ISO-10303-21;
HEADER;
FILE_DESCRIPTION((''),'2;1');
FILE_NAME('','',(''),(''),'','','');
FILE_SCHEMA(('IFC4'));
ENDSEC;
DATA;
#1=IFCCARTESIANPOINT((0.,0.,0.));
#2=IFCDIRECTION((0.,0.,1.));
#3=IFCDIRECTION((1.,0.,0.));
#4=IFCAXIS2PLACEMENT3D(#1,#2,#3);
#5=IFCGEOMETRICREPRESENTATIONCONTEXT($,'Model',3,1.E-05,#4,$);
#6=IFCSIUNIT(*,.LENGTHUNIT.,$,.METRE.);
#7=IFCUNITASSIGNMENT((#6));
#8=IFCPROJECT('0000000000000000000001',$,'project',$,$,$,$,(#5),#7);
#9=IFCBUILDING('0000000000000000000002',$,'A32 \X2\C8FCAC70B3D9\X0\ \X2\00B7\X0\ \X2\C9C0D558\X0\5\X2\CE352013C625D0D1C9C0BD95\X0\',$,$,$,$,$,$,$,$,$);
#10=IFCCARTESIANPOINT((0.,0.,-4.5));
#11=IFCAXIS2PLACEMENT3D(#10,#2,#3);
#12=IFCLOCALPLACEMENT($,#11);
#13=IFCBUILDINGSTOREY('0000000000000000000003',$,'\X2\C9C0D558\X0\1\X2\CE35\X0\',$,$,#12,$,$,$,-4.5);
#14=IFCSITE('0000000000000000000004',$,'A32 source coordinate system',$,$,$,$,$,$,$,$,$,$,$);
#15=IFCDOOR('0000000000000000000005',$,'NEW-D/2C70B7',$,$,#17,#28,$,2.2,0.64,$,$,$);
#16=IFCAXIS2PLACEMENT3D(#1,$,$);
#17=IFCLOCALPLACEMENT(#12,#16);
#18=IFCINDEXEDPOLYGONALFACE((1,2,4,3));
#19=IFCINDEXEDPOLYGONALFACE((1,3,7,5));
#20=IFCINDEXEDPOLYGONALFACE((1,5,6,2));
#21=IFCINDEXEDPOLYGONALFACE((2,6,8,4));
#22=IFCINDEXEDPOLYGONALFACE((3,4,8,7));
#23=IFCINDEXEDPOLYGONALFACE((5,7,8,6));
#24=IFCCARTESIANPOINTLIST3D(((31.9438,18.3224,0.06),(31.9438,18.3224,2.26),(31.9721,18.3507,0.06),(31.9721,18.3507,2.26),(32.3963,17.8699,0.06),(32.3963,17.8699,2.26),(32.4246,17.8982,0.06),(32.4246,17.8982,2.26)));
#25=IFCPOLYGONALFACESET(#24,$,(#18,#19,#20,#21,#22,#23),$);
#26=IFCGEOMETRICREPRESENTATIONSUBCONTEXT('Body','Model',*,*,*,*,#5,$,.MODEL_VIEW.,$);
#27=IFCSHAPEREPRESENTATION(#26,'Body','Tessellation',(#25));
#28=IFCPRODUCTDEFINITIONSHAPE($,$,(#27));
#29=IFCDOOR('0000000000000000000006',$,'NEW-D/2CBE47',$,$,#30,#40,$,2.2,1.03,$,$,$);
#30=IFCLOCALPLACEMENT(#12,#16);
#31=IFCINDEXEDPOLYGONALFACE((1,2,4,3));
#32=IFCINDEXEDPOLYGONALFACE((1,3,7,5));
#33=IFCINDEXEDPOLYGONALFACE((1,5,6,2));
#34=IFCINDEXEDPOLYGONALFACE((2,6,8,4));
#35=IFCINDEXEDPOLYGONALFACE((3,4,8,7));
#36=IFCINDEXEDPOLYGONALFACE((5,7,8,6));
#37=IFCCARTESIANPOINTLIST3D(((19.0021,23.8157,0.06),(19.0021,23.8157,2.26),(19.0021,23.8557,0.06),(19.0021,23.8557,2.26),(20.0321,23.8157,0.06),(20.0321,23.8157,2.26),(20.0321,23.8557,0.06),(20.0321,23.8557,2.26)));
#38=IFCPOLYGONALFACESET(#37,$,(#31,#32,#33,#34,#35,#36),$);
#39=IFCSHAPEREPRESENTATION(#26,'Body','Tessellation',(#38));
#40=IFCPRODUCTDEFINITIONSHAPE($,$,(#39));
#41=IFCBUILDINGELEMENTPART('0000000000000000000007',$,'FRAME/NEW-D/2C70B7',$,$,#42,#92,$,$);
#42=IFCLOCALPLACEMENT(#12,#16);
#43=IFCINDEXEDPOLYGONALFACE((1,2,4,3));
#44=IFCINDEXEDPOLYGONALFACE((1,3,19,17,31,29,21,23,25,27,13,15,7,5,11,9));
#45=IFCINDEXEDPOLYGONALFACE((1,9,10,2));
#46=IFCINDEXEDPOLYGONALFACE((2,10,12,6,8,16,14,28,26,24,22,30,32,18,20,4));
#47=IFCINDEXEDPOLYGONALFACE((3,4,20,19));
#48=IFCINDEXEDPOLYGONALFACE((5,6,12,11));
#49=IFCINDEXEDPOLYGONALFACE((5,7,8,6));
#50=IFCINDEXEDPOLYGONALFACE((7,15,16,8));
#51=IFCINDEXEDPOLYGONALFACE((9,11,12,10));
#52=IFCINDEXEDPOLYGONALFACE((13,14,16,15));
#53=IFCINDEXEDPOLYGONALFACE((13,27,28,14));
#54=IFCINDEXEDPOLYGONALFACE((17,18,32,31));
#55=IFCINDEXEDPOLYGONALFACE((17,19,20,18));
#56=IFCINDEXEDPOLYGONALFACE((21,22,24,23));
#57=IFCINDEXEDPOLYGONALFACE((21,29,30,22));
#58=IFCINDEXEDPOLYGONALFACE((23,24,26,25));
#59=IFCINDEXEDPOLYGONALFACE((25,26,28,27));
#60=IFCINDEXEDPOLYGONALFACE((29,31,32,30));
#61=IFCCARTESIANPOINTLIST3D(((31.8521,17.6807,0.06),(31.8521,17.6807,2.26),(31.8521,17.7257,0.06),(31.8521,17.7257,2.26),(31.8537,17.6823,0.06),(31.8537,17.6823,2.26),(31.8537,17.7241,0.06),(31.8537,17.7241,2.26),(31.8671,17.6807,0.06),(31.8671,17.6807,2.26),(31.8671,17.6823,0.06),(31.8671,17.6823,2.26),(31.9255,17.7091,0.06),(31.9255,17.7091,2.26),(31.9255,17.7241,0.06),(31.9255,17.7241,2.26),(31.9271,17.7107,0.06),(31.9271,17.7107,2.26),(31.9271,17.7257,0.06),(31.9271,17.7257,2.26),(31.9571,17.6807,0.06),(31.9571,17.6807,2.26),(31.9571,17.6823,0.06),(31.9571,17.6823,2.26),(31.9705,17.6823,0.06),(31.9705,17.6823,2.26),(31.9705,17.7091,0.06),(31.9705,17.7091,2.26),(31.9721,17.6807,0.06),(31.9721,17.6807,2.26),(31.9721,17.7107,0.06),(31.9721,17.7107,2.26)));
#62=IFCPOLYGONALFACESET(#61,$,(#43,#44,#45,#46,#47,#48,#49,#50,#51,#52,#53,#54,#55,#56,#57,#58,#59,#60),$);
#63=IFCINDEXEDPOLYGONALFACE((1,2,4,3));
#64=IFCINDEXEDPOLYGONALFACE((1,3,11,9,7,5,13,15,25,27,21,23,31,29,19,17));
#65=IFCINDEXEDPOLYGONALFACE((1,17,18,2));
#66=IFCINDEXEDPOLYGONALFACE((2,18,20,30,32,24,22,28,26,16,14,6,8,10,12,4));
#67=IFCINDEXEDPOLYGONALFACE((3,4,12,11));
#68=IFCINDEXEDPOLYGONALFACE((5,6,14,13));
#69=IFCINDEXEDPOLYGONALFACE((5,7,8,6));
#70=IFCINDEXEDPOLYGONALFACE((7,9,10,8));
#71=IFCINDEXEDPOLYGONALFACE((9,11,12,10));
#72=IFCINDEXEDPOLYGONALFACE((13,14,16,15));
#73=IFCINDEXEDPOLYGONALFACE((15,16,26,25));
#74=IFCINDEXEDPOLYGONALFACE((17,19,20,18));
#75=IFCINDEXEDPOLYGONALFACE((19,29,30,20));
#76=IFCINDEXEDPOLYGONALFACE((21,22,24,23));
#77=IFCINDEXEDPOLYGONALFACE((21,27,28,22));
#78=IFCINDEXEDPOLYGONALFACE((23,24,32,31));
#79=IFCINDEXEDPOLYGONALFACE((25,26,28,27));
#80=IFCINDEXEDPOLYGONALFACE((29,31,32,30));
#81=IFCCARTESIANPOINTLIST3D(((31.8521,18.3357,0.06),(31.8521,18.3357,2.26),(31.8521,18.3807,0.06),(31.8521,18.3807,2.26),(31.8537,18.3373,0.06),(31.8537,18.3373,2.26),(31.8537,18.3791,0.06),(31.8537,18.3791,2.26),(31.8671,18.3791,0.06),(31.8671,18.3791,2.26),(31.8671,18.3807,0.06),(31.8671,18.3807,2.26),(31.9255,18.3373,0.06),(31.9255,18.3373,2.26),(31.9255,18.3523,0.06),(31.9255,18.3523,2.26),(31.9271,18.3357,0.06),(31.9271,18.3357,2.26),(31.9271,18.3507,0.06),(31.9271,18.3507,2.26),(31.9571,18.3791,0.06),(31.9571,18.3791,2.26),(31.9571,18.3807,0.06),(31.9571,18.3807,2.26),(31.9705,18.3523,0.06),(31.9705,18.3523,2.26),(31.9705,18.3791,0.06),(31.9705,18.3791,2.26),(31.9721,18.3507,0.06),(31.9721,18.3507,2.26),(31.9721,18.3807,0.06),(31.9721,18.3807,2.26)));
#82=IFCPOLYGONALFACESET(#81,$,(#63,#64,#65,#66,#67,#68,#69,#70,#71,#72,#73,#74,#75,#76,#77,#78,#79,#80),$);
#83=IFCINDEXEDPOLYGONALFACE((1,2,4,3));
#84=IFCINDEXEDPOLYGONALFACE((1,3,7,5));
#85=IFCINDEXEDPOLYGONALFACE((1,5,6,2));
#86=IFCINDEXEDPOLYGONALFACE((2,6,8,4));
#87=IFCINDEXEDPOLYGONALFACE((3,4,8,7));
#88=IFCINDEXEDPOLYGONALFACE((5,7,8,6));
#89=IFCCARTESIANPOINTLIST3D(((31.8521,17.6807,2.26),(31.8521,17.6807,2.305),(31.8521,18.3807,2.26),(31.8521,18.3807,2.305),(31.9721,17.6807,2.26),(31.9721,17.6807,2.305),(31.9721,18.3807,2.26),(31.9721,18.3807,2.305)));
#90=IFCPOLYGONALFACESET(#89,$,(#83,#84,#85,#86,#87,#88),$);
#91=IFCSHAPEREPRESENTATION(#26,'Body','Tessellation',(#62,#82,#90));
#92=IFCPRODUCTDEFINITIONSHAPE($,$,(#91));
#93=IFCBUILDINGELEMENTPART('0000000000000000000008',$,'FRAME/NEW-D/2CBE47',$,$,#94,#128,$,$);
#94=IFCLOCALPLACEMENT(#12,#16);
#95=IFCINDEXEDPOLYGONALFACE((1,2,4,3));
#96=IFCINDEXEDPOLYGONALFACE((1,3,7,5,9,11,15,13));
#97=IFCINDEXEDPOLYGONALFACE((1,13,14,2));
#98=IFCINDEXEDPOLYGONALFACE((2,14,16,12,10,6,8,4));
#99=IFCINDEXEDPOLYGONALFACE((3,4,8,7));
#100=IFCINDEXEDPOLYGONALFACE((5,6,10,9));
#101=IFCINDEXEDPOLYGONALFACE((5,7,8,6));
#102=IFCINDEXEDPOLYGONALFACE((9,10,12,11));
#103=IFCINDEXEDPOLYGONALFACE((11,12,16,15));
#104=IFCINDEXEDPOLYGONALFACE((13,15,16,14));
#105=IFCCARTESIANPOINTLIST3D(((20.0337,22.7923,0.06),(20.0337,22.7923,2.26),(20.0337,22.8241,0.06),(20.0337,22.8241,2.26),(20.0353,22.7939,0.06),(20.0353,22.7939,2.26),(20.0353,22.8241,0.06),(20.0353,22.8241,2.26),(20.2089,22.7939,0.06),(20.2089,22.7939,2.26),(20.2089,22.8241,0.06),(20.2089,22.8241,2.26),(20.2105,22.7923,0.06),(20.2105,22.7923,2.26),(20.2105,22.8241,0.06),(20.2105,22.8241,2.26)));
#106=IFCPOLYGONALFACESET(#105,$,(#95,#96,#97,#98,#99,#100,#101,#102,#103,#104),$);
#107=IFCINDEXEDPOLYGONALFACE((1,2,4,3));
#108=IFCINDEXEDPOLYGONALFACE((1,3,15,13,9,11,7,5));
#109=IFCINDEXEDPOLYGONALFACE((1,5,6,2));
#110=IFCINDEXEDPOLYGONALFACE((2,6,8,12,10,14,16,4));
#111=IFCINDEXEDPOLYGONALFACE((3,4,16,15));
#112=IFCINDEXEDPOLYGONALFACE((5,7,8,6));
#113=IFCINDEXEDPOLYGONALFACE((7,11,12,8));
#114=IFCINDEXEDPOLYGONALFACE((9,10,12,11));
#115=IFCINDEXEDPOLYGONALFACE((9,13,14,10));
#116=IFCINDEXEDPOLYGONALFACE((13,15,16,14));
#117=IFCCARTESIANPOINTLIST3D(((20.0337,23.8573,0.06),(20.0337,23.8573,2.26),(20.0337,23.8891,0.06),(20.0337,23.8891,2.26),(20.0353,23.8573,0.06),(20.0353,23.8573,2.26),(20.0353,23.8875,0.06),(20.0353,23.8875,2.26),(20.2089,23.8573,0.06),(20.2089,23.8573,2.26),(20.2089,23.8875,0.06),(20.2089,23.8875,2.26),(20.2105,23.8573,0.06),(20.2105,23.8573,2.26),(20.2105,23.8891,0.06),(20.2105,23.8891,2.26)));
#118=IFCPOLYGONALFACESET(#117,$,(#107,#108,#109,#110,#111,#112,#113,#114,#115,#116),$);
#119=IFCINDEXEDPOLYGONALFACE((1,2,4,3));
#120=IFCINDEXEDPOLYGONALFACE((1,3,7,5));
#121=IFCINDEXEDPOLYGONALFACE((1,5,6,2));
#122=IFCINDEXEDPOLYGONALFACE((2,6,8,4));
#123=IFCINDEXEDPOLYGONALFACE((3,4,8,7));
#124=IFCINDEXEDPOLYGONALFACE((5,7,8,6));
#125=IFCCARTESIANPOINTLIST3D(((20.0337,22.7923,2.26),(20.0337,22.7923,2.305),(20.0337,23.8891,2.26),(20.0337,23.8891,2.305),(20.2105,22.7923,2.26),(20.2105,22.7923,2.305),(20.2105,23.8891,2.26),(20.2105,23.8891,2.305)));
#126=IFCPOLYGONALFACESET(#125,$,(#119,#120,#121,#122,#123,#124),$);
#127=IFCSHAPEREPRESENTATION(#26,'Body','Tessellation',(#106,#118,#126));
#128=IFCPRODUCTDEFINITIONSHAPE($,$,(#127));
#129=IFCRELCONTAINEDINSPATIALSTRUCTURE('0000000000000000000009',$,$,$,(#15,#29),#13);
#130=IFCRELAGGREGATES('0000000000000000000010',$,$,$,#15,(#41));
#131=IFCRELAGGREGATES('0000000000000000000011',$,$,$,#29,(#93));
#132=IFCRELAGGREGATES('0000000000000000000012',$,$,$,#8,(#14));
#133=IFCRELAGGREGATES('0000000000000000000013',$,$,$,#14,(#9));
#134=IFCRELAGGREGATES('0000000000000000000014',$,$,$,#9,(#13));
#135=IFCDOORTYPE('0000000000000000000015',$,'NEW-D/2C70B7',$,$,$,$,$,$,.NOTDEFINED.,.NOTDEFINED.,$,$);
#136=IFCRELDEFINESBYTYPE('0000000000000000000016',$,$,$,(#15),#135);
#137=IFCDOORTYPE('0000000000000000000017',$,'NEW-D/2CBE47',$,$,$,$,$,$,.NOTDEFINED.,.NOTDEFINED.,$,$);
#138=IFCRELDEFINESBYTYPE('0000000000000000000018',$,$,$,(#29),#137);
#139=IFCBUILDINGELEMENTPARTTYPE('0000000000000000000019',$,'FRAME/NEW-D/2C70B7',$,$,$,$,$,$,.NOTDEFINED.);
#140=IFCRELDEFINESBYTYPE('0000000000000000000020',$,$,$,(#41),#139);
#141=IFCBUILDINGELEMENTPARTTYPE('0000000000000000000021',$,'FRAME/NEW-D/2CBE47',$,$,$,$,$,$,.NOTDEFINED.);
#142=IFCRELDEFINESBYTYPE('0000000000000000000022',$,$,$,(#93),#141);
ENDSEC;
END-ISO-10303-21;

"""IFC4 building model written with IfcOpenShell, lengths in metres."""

from ifc_helpers import new_model, si_unit, frame, origin, origin_with_axes, place, context, subcontext, project, spatial, polyline, outline, extrude, source, transform, mapped, type_object, type_shapes, element, aggregate, save


model = new_model("IFC4")

# Units and contexts
model_context = context("Model", 3, precision=1e-05, world=origin_with_axes())
body_context = subcontext(model_context, "Body", "Model", "MODEL_VIEW")
ifc_project = project(units=[si_unit("LENGTHUNIT", "METRE")], contexts=[model_context])

# Site, building, storey
site = spatial("IfcSite", under=ifc_project, Name="A32 source coordinate system")
building = spatial("IfcBuilding", under=site, Name="A32 주거동 · 지하5층–옥탑지붕")
storey_placement = place(None, frame((0.0, 0.0, -4.5), z_axis=(0.0, 0.0, 1.0), x_axis=(1.0, 0.0, 0.0)))
storey = spatial("IfcBuildingStorey", under=building, at=storey_placement, Name="지하1층", Elevation=-4.5)

# Doors
door_type_1 = type_object("IfcDoorType", Name="NEW-D/2C70B7", OperationType="NOTDEFINED", PredefinedType="NOTDEFINED")
shared_shape_1 = source(origin(), body_context, "Body", "SweptSolid", [
    extrude(outline(polyline([(32.3963, 17.8699), (31.9438, 18.3224), (31.9721, 18.3507), (32.4246, 17.8982), (32.3963, 17.8699)])), frame((0.0, 0.0, 0.06)), (0.0, 0.0, 1.0), 2.2),
])
type_shapes(door_type_1, [shared_shape_1])
door_1_placement = place(storey_placement, origin_with_axes())
door_1 = element("IfcDoor", 1, at=door_1_placement, inside=storey, type_object=door_type_1, Name="NEW-D/2C70B7", OverallHeight=2.2, OverallWidth=0.64, context=body_context, shape_type="MappedRepresentation", body=[
    mapped(shared_shape_1, transform((0.0, 0.0, 0.0), scale=1.0)),
])
door_type_2 = type_object("IfcDoorType", Name="NEW-D/2CBE47", OperationType="NOTDEFINED", PredefinedType="NOTDEFINED")
shared_shape_2 = source(origin(), body_context, "Body", "SweptSolid", [
    extrude(outline(polyline([(20.0321, 23.8557), (20.0321, 23.8157), (19.0021, 23.8157), (19.0021, 23.8557), (20.0321, 23.8557)])), frame((0.0, 0.0, 0.06)), (0.0, 0.0, 1.0), 2.2),
])
type_shapes(door_type_2, [shared_shape_2])
door_2_placement = place(storey_placement, origin_with_axes())
door_2 = element("IfcDoor", 2, at=door_2_placement, inside=storey, type_object=door_type_2, Name="NEW-D/2CBE47", OverallHeight=2.2, OverallWidth=1.03, context=body_context, shape_type="MappedRepresentation", body=[
    mapped(shared_shape_2, transform((0.0, 0.0, 0.0), scale=1.0)),
])

# Building element parts
building_element_part_type_1 = type_object("IfcBuildingElementPartType", Name="FRAME/NEW-D/2C70B7", PredefinedType="NOTDEFINED")
shared_shape_3 = source(origin(), body_context, "Body", "SweptSolid", [
    extrude(outline(polyline([(31.9705, 17.7091), (31.9255, 17.7091), (31.9255, 17.7241), (31.8537, 17.7241), (31.8537, 17.6823), (31.8671, 17.6823), (31.8671, 17.6807), (31.8521, 17.6807), (31.8521, 17.7257), (31.9271, 17.7257), (31.9271, 17.7107), (31.9721, 17.7107), (31.9721, 17.6807), (31.9571, 17.6807), (31.9571, 17.6823), (31.9705, 17.6823), (31.9705, 17.7091)])), frame((0.0, 0.0, 0.06)), (0.0, 0.0, 1.0), 2.2),
    extrude(outline(polyline([(31.9721, 18.3807), (31.9721, 18.3507), (31.9271, 18.3507), (31.9271, 18.3357), (31.8521, 18.3357), (31.8521, 18.3807), (31.8671, 18.3807), (31.8671, 18.3791), (31.8537, 18.3791), (31.8537, 18.3373), (31.9255, 18.3373), (31.9255, 18.3523), (31.9705, 18.3523), (31.9705, 18.3791), (31.9571, 18.3791), (31.9571, 18.3807), (31.9721, 18.3807)])), frame((0.0, 0.0, 0.06)), (0.0, 0.0, 1.0), 2.2),
    extrude(outline(polyline([(31.9721, 17.6807), (31.9721, 18.3807), (31.8521, 18.3807), (31.8521, 17.6807), (31.9721, 17.6807)])), frame((0.0, 0.0, 2.26)), (0.0, 0.0, 1.0), 0.045),
])
type_shapes(building_element_part_type_1, [shared_shape_3])
building_element_part_1_placement = place(door_1_placement, origin_with_axes())
building_element_part_1 = element("IfcBuildingElementPart", 3, at=building_element_part_1_placement, type_object=building_element_part_type_1, Name="FRAME/NEW-D/2C70B7", context=body_context, shape_type="MappedRepresentation", body=[
    mapped(shared_shape_3, transform((0.0, 0.0, 0.0), scale=1.0)),
])
aggregate(door_1, [building_element_part_1])
building_element_part_type_2 = type_object("IfcBuildingElementPartType", Name="FRAME/NEW-D/2CBE47", PredefinedType="NOTDEFINED")
shared_shape_4 = source(origin(), body_context, "Body", "SweptSolid", [
    extrude(outline(polyline([(20.0353, 22.7939), (20.2089, 22.7939), (20.2089, 22.8241), (20.2105, 22.8241), (20.2105, 22.7923), (20.0337, 22.7923), (20.0337, 22.8241), (20.0353, 22.8241), (20.0353, 22.7939)])), frame((0.0, 0.0, 0.06)), (0.0, 0.0, 1.0), 2.2),
    extrude(outline(polyline([(20.2105, 23.8891), (20.2105, 23.8573), (20.2089, 23.8573), (20.2089, 23.8875), (20.0353, 23.8875), (20.0353, 23.8573), (20.0337, 23.8573), (20.0337, 23.8891), (20.2105, 23.8891)])), frame((0.0, 0.0, 0.06)), (0.0, 0.0, 1.0), 2.2),
    extrude(outline(polyline([(20.2105, 22.7923), (20.2105, 23.8891), (20.0337, 23.8891), (20.0337, 22.7923), (20.2105, 22.7923)])), frame((0.0, 0.0, 2.26)), (0.0, 0.0, 1.0), 0.045),
])
type_shapes(building_element_part_type_2, [shared_shape_4])
building_element_part_2_placement = place(door_2_placement, origin_with_axes())
building_element_part_2 = element("IfcBuildingElementPart", 4, at=building_element_part_2_placement, type_object=building_element_part_type_2, Name="FRAME/NEW-D/2CBE47", context=body_context, shape_type="MappedRepresentation", body=[
    mapped(shared_shape_4, transform((0.0, 0.0, 0.0), scale=1.0)),
])
aggregate(door_2, [building_element_part_2])

save(model, "model.ifc")
